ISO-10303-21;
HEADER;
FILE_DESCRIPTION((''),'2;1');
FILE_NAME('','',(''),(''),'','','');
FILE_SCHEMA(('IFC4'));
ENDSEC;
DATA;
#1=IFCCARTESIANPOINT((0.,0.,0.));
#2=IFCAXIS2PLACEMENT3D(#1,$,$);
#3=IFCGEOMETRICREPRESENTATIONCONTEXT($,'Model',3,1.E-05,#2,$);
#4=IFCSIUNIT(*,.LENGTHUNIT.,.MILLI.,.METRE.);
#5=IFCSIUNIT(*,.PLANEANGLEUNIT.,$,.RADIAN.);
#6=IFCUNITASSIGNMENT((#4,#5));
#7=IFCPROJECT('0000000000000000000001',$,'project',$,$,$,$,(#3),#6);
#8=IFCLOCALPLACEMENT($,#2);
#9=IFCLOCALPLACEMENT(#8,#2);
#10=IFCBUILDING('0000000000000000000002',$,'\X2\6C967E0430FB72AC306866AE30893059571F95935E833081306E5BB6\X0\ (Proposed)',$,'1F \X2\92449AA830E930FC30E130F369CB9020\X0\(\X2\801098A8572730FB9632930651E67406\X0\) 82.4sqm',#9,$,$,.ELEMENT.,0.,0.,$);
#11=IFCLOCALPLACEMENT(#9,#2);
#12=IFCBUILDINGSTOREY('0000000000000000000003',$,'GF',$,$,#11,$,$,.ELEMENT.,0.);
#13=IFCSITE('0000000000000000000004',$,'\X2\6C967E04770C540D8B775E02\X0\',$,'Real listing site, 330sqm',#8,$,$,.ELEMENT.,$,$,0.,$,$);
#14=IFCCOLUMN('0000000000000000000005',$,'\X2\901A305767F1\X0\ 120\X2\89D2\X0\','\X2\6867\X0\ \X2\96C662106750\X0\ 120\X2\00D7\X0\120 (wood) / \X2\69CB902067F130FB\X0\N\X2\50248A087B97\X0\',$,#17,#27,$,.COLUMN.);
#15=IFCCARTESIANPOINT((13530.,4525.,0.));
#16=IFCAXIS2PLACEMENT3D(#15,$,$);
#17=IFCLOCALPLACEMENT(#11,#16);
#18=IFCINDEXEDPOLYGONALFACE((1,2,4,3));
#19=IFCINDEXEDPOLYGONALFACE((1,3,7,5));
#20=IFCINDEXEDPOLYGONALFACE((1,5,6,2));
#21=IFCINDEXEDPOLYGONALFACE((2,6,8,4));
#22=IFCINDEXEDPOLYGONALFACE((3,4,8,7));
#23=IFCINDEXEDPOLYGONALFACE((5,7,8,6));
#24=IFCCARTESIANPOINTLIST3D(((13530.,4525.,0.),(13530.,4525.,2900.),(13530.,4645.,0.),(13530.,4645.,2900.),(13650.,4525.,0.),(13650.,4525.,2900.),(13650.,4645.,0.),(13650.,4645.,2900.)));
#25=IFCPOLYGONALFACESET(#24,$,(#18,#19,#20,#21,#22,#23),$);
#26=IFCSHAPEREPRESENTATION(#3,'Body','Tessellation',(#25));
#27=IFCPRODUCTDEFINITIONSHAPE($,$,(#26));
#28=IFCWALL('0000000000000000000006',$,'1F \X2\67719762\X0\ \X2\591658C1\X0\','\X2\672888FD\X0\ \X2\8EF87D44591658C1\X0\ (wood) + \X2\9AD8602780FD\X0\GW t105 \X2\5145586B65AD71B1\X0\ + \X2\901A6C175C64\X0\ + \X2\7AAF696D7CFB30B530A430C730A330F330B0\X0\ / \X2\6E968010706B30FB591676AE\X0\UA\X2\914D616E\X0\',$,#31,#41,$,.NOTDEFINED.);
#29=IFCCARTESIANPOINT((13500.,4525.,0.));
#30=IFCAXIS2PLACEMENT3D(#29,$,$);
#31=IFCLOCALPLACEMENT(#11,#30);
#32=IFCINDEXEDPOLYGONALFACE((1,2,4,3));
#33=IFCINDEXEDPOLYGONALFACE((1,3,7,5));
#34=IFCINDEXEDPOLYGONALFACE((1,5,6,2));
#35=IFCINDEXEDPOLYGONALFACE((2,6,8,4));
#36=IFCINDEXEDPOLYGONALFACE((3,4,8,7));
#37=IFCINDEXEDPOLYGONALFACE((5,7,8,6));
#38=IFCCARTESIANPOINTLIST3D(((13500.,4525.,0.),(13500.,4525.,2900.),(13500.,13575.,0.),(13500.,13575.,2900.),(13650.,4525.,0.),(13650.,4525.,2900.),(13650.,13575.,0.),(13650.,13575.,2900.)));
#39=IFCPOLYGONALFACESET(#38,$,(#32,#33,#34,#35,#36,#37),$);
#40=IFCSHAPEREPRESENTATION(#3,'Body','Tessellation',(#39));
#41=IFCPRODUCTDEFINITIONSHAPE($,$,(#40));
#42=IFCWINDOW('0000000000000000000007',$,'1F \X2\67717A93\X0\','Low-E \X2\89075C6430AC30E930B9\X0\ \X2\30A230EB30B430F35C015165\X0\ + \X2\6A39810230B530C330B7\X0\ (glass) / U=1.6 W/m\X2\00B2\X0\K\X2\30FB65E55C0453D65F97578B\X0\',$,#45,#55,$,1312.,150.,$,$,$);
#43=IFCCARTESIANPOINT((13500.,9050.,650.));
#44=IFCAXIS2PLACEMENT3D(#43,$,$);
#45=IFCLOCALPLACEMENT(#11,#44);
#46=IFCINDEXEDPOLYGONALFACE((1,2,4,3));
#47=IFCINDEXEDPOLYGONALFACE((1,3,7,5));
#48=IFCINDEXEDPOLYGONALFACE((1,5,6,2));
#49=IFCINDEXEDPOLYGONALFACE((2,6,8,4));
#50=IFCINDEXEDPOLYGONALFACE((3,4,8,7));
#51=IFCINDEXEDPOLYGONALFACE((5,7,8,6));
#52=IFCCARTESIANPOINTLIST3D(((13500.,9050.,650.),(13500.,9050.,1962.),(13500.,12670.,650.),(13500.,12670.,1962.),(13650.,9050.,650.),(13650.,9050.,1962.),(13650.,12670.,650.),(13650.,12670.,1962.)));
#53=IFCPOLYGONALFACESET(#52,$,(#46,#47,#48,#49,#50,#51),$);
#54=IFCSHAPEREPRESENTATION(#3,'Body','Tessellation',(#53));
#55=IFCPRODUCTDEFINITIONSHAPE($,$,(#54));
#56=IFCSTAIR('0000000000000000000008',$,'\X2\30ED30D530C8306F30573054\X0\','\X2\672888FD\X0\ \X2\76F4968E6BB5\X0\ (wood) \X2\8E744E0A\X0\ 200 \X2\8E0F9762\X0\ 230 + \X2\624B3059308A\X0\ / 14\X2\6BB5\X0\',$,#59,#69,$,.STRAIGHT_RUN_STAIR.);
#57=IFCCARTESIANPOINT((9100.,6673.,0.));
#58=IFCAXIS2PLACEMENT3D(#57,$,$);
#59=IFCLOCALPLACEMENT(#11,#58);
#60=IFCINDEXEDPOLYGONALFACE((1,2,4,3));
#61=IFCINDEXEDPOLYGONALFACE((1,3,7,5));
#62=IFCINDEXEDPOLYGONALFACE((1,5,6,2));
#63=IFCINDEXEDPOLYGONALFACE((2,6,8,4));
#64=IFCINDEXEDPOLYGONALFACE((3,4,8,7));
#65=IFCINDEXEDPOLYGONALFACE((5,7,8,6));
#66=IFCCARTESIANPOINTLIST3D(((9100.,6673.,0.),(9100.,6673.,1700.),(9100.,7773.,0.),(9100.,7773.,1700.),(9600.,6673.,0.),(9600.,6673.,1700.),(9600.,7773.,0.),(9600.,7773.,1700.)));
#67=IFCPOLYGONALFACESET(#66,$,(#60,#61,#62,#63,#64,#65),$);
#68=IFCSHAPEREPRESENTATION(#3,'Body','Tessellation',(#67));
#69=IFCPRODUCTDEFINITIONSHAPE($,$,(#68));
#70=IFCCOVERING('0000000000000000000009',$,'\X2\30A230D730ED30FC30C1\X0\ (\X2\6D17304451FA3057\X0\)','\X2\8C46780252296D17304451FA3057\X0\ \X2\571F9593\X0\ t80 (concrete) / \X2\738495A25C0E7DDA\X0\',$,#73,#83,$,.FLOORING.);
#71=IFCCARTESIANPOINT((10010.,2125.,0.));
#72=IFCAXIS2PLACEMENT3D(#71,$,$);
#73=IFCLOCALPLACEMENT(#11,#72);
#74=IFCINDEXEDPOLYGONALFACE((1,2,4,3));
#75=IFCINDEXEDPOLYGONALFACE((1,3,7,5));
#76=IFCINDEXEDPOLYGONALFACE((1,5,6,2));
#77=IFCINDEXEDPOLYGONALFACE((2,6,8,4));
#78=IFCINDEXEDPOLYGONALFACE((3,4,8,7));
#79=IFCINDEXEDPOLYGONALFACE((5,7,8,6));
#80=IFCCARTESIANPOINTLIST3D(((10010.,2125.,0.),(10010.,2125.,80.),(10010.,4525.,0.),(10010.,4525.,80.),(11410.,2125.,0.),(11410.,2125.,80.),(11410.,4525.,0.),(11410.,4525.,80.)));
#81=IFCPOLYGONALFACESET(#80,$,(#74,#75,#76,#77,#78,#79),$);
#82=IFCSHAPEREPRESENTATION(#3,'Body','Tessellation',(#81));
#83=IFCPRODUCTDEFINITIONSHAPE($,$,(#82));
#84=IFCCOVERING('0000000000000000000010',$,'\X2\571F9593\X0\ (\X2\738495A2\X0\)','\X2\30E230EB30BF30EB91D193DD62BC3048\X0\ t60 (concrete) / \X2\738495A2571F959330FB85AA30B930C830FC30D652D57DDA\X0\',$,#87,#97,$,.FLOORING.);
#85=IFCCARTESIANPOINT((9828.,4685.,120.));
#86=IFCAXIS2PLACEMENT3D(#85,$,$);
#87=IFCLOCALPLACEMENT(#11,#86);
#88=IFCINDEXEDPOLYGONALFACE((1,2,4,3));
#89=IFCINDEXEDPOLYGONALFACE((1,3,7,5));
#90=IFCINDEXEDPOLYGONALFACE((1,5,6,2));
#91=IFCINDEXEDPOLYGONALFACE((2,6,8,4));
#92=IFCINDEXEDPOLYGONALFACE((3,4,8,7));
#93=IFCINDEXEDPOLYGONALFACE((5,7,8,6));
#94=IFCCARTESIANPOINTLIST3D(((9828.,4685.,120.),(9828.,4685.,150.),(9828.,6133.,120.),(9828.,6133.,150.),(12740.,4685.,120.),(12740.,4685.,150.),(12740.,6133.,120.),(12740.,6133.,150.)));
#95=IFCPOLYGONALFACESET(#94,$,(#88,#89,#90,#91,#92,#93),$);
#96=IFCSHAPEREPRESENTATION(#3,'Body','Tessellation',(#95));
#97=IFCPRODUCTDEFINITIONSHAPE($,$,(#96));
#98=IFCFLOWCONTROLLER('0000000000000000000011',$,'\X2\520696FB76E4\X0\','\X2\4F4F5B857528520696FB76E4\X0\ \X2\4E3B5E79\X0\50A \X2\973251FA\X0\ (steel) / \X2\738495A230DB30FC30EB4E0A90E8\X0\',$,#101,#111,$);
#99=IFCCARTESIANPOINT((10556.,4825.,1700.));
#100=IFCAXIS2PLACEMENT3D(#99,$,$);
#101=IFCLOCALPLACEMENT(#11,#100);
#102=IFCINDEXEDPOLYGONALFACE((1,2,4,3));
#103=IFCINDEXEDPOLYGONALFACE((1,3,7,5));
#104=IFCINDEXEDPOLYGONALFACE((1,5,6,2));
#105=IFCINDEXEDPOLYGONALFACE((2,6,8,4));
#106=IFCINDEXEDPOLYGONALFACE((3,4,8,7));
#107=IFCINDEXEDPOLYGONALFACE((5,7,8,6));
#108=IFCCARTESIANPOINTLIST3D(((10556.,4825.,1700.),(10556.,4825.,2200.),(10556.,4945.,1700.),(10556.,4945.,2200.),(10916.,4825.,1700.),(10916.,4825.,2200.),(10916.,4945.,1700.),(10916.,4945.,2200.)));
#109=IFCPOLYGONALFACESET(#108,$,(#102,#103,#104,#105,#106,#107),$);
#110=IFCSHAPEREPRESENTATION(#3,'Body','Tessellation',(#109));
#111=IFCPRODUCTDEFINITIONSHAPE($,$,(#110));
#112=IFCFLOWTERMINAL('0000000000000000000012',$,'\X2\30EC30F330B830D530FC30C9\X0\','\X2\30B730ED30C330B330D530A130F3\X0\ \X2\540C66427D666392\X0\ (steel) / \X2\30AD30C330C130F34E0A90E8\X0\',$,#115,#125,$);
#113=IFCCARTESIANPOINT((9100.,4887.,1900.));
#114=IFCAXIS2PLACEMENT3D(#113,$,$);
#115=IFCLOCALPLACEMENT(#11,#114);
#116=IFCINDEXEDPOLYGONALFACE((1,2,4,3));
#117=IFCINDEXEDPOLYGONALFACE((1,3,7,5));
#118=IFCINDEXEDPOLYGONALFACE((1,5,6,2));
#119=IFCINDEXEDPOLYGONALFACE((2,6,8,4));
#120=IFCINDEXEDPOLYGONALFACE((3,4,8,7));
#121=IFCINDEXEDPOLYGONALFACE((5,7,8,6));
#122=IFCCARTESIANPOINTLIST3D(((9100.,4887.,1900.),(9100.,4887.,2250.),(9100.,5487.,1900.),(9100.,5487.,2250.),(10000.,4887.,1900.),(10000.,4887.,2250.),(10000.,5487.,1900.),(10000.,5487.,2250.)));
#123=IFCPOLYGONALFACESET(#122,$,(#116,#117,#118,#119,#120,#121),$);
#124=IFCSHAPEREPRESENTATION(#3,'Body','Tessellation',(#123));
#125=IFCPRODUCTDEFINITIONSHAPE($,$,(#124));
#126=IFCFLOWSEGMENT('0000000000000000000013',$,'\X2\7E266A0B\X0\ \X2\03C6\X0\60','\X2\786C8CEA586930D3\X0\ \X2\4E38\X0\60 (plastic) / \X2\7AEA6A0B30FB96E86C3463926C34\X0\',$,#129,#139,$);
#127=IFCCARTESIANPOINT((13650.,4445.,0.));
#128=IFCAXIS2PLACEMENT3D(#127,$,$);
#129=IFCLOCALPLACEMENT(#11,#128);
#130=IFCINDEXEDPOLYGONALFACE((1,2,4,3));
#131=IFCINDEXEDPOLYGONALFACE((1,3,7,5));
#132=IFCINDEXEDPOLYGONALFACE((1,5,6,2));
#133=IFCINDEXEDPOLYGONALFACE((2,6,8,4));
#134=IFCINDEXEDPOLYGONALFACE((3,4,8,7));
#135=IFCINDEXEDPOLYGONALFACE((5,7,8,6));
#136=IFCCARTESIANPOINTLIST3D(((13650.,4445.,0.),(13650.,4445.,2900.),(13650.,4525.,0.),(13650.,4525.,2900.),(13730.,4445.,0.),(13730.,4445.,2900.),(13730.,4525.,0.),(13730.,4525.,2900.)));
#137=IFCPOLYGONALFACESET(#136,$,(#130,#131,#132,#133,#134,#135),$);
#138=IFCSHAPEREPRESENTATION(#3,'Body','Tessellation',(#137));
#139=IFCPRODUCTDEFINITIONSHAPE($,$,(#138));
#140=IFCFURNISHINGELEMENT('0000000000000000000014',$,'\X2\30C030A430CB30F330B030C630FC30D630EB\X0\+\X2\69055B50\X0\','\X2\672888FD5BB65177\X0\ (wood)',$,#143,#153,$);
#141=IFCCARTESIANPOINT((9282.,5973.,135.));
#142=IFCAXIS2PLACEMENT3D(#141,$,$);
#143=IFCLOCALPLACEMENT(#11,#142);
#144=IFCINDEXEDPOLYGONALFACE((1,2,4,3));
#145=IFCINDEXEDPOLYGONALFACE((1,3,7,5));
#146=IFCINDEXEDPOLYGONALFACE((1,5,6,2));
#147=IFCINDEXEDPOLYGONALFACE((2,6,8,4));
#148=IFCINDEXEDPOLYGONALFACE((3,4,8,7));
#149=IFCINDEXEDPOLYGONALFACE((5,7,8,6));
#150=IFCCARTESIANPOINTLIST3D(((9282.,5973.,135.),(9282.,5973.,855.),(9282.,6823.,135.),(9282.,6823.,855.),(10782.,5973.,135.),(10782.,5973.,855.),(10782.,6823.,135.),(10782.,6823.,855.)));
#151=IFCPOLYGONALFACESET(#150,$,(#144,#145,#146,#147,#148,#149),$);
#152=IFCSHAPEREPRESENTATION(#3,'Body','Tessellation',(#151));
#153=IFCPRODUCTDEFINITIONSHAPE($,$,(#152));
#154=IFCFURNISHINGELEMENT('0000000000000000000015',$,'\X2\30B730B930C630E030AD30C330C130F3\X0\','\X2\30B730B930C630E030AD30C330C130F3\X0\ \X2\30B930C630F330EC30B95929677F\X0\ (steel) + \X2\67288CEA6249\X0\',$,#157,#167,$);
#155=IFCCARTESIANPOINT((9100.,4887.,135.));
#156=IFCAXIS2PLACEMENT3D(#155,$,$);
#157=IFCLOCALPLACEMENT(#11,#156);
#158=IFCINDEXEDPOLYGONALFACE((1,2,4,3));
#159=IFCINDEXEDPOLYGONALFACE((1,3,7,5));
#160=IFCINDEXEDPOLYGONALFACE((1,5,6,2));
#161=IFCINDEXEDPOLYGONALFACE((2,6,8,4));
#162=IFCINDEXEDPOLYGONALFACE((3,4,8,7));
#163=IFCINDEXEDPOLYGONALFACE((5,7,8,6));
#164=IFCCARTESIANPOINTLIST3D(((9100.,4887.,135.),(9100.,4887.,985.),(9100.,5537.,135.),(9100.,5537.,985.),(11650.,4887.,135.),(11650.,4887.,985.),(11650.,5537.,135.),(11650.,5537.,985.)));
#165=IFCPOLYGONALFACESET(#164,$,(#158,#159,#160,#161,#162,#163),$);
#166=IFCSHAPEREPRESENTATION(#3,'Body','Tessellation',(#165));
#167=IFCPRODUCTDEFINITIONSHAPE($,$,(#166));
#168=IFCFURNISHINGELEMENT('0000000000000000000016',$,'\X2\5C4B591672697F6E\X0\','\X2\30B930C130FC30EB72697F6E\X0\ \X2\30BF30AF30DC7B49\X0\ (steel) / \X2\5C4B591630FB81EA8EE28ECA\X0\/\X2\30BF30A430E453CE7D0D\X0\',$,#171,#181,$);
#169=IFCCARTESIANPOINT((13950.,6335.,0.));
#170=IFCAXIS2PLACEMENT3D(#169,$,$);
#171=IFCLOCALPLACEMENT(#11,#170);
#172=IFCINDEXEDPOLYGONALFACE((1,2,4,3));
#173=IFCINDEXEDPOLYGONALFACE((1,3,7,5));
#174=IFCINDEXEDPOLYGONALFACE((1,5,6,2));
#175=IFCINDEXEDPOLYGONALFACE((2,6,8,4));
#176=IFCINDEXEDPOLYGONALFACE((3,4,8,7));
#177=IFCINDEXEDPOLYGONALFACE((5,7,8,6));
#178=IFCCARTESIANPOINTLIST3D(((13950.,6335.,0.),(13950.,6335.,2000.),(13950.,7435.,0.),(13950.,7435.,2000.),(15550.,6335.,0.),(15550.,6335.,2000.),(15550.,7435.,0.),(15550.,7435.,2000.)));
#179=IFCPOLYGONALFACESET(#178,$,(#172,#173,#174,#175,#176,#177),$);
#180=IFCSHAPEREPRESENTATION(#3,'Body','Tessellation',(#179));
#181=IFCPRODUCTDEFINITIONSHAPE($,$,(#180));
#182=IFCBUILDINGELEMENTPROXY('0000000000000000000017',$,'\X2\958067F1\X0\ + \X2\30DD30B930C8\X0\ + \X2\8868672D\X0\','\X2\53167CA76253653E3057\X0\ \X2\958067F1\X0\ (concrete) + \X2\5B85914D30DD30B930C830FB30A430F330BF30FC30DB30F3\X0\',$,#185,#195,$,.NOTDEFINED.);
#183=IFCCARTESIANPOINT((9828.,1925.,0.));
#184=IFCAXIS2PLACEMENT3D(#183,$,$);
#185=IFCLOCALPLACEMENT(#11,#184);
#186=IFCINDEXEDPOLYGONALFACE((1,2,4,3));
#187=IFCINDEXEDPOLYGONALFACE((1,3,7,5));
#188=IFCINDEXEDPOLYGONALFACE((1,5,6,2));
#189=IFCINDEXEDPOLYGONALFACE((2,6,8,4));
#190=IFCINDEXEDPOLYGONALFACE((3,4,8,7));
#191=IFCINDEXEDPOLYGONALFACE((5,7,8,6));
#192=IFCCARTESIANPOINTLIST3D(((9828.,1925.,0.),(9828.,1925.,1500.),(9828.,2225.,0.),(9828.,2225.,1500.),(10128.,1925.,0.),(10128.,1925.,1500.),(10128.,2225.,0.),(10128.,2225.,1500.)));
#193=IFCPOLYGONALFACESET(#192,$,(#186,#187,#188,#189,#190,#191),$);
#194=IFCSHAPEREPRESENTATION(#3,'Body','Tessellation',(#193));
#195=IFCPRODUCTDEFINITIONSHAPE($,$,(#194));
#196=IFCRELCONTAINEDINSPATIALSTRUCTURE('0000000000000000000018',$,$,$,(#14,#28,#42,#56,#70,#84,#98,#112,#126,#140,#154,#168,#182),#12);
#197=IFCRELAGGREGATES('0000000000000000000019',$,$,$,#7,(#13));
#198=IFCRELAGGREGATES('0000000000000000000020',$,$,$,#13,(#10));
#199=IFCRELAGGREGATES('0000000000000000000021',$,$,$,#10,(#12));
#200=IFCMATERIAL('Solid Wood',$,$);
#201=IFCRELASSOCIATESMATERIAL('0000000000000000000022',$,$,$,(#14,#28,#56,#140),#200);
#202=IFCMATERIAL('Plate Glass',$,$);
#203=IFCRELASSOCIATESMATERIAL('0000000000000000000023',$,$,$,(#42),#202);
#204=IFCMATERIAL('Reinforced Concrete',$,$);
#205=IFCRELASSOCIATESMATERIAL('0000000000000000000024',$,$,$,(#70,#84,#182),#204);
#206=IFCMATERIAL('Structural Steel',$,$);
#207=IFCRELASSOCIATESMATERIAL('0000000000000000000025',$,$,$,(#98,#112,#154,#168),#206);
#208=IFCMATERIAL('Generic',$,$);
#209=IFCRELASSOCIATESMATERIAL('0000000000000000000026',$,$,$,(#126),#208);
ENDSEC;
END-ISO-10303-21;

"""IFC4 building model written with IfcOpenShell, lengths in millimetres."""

from ifc_helpers import new_model, si_unit, frame, frame_2d, origin, place, context, project, spatial, rectangle, extrude, material, element, fill, save


model = new_model("IFC4")

# Units and contexts
model_context = context("Model", 3, precision=1e-05, world=origin())
ifc_project = project(units=[si_unit("LENGTHUNIT", "METRE", prefix="MILLI"), si_unit("PLANEANGLEUNIT", "RADIAN")], contexts=[model_context])

# Site, building, storey
site_placement = place(None, origin())
site = spatial("IfcSite", under=ifc_project, at=site_placement, Name="沖縄県名護市", ObjectType="Real listing site, 330sqm", CompositionType="ELEMENT", RefElevation=0.0)
building_placement = place(site_placement, origin())
building = spatial("IfcBuilding", under=site, at=building_placement, Name="沖縄・犬と暮らす土間広めの家 (Proposed)", ObjectType="1F 鉄骨ラーメン構造(耐風圧・防錆処理) 82.4sqm", CompositionType="ELEMENT", ElevationOfRefHeight=0.0, ElevationOfTerrain=0.0)
storey_placement = place(building_placement, origin())
storey = spatial("IfcBuildingStorey", under=building, at=storey_placement, Name="GF", CompositionType="ELEMENT", Elevation=0.0)

# Column
ifc_material_1 = material(Name="Solid Wood")
column_1_placement = place(storey_placement, frame((13530.0, 4525.0, 0.0)))
element("IfcColumn", 1, at=column_1_placement, inside=storey, material=ifc_material_1, Name="通し柱 120角", Description="桧 集成材 120×120 (wood) / 構造柱・N値計算", PredefinedType="COLUMN", context=model_context, shape_type="SweptSolid", body=[
    extrude(rectangle(XDim=120.0, YDim=120.0, at=frame_2d((60.0, 60.0))), frame((13530.0, 4525.0, 0.0)), (0.0, 0.0, 1.0), 2900.0),
])

# Wall, opening, window
wall_1_placement = place(storey_placement, frame((13500.0, 4525.0, 0.0)))
wall_1 = element("IfcWall", 2, at=wall_1_placement, inside=storey, material=ifc_material_1, Name="1F 東面 外壁", Description="木製 軸組外壁 (wood) + 高性能GW t105 充填断熱 + 通気層 + 窯業系サイディング / 準耐火・外皮UA配慮", PredefinedType="NOTDEFINED", context=model_context, shape_type="SweptSolid", body=[
    extrude(rectangle(XDim=150.0, YDim=9050.0, at=frame_2d((75.0, 4525.0))), frame((13500.0, 4525.0, 0.0)), (0.0, 0.0, 1.0), 2900.0),
])
opening_placement = place(storey_placement, frame((13500.0, 9050.0, 650.0)))
opening = element("IfcOpeningElement", 3, at=opening_placement, cuts=wall_1, PredefinedType="NOTDEFINED", context=model_context, shape_type="SweptSolid", body=[
    extrude(rectangle(XDim=150.0, YDim=3620.0, at=frame_2d((75.0, 1810.0))), frame((13500.0, 9050.0, 650.0)), (0.0, 0.0, 1.0), 1312.0),
])
ifc_material_2 = material(Name="Plate Glass")
window_placement = place(storey_placement, frame((13500.0, 9050.0, 650.0)))
window = element("IfcWindow", 4, at=window_placement, inside=storey, material=ifc_material_2, Name="1F 東窓", Description="Low-E 複層ガラス アルゴン封入 + 樹脂サッシ (glass) / U=1.6 W/m²K・日射取得型", OverallHeight=1312.0, OverallWidth=150.0, context=model_context, shape_type="SweptSolid", body=[
    extrude(rectangle(XDim=150.0, YDim=3620.0, at=frame_2d((75.0, 1810.0))), frame((13500.0, 9050.0, 650.0)), (0.0, 0.0, 1.0), 1312.0),
])
fill(opening, window)

# Stair
stair_placement = place(storey_placement, frame((9100.0, 6673.0, 0.0)))
element("IfcStair", 5, at=stair_placement, inside=storey, material=ifc_material_1, Name="ロフトはしご", Description="木製 直階段 (wood) 蹴上 200 踏面 230 + 手すり / 14段", PredefinedType="STRAIGHT_RUN_STAIR", context=model_context, shape_type="SweptSolid", body=[
    extrude(rectangle(XDim=500.0, YDim=1100.0, at=frame_2d((250.0, 550.0))), frame((9100.0, 6673.0, 0.0)), (0.0, 0.0, 1.0), 1700.0),
])

# Coverings
ifc_material_3 = material(Name="Reinforced Concrete")
covering_1_placement = place(storey_placement, frame((10010.0, 2125.0, 0.0)))
element("IfcCovering", 6, at=covering_1_placement, inside=storey, material=ifc_material_3, Name="アプローチ (洗い出し)", Description="豆砂利洗い出し 土間 t80 (concrete) / 玄関導線", PredefinedType="FLOORING", context=model_context, shape_type="SweptSolid", body=[
    extrude(rectangle(XDim=1400.0, YDim=2400.0, at=frame_2d((700.0, 1200.0))), frame((10010.0, 2125.0, 0.0)), (0.0, 0.0, 1.0), 80.0),
])
covering_2_placement = place(storey_placement, frame((9828.0, 4685.0, 120.0)))
element("IfcCovering", 7, at=covering_2_placement, inside=storey, material=ifc_material_3, Name="土間 (玄関)", Description="モルタル金鏝押え t60 (concrete) / 玄関土間・薪ストーブ動線", PredefinedType="FLOORING", context=model_context, shape_type="SweptSolid", body=[
    extrude(rectangle(XDim=2912.0, YDim=1448.0, at=frame_2d((1456.0, 724.0))), frame((9828.0, 4685.0, 120.0)), (0.0, 0.0, 1.0), 30.0),
])

# Flow controller
ifc_material_4 = material(Name="Structural Steel")
flow_controller_placement = place(storey_placement, frame((10556.0, 4825.0, 1700.0)))
element("IfcFlowController", 8, at=flow_controller_placement, inside=storey, material=ifc_material_4, Name="分電盤", Description="住宅用分電盤 主幹50A 露出 (steel) / 玄関ホール上部", context=model_context, shape_type="SweptSolid", body=[
    extrude(rectangle(XDim=360.0, YDim=120.0, at=frame_2d((180.0, 60.0))), frame((10556.0, 4825.0, 1700.0)), (0.0, 0.0, 1.0), 500.0),
])

# Flow terminal
flow_terminal_placement = place(storey_placement, frame((9100.0, 4887.0, 1900.0)))
element("IfcFlowTerminal", 9, at=flow_terminal_placement, inside=storey, material=ifc_material_4, Name="レンジフード", Description="シロッコファン 同時給排 (steel) / キッチン上部", context=model_context, shape_type="SweptSolid", body=[
    extrude(rectangle(XDim=900.0, YDim=600.0, at=frame_2d((450.0, 300.0))), frame((9100.0, 4887.0, 1900.0)), (0.0, 0.0, 1.0), 350.0),
])

# Flow segment
ifc_material_5 = material(Name="Generic")
flow_segment_placement = place(storey_placement, frame((13650.0, 4445.0, 0.0)))
element("IfcFlowSegment", 10, at=flow_segment_placement, inside=storey, material=ifc_material_5, Name="縦樋 φ60", Description="硬質塩ビ 丸60 (plastic) / 竪樋・雨水排水", context=model_context, shape_type="SweptSolid", body=[
    extrude(rectangle(XDim=80.0, YDim=80.0, at=frame_2d((40.0, 40.0))), frame((13650.0, 4445.0, 0.0)), (0.0, 0.0, 1.0), 2900.0),
])

# Furnishing elements
furnishing_1_placement = place(storey_placement, frame((9282.0, 5973.0, 135.0)))
element("IfcFurnishingElement", 11, at=furnishing_1_placement, inside=storey, material=ifc_material_1, Name="ダイニングテーブル+椅子", Description="木製家具 (wood)", context=model_context, shape_type="SweptSolid", body=[
    extrude(rectangle(XDim=1500.0, YDim=850.0, at=frame_2d((750.0, 425.0))), frame((9282.0, 5973.0, 135.0)), (0.0, 0.0, 1.0), 720.0),
])
furnishing_2_placement = place(storey_placement, frame((9100.0, 4887.0, 135.0)))
element("IfcFurnishingElement", 12, at=furnishing_2_placement, inside=storey, material=ifc_material_4, Name="システムキッチン", Description="システムキッチン ステンレス天板 (steel) + 木質扉", context=model_context, shape_type="SweptSolid", body=[
    extrude(rectangle(XDim=2550.0, YDim=650.0, at=frame_2d((1275.0, 325.0))), frame((9100.0, 4887.0, 135.0)), (0.0, 0.0, 1.0), 850.0),
])
furnishing_3_placement = place(storey_placement, frame((13950.0, 6335.0, 0.0)))
element("IfcFurnishingElement", 13, at=furnishing_3_placement, inside=storey, material=ifc_material_4, Name="屋外物置", Description="スチール物置 タクボ等 (steel) / 屋外・自転車/タイヤ収納", context=model_context, shape_type="SweptSolid", body=[
    extrude(rectangle(XDim=1600.0, YDim=1100.0, at=frame_2d((800.0, 550.0))), frame((13950.0, 6335.0, 0.0)), (0.0, 0.0, 1.0), 2000.0),
])

# Building element proxy
proxy_placement = place(storey_placement, frame((9828.0, 1925.0, 0.0)))
element("IfcBuildingElementProxy", 14, at=proxy_placement, inside=storey, material=ifc_material_3, Name="門柱 + ポスト + 表札", Description="化粧打放し 門柱 (concrete) + 宅配ポスト・インターホン", PredefinedType="NOTDEFINED", context=model_context, shape_type="SweptSolid", body=[
    extrude(rectangle(XDim=300.0, YDim=300.0, at=frame_2d((150.0, 150.0))), frame((9828.0, 1925.0, 0.0)), (0.0, 0.0, 1.0), 1500.0),
])

save(model, "model.ifc")
